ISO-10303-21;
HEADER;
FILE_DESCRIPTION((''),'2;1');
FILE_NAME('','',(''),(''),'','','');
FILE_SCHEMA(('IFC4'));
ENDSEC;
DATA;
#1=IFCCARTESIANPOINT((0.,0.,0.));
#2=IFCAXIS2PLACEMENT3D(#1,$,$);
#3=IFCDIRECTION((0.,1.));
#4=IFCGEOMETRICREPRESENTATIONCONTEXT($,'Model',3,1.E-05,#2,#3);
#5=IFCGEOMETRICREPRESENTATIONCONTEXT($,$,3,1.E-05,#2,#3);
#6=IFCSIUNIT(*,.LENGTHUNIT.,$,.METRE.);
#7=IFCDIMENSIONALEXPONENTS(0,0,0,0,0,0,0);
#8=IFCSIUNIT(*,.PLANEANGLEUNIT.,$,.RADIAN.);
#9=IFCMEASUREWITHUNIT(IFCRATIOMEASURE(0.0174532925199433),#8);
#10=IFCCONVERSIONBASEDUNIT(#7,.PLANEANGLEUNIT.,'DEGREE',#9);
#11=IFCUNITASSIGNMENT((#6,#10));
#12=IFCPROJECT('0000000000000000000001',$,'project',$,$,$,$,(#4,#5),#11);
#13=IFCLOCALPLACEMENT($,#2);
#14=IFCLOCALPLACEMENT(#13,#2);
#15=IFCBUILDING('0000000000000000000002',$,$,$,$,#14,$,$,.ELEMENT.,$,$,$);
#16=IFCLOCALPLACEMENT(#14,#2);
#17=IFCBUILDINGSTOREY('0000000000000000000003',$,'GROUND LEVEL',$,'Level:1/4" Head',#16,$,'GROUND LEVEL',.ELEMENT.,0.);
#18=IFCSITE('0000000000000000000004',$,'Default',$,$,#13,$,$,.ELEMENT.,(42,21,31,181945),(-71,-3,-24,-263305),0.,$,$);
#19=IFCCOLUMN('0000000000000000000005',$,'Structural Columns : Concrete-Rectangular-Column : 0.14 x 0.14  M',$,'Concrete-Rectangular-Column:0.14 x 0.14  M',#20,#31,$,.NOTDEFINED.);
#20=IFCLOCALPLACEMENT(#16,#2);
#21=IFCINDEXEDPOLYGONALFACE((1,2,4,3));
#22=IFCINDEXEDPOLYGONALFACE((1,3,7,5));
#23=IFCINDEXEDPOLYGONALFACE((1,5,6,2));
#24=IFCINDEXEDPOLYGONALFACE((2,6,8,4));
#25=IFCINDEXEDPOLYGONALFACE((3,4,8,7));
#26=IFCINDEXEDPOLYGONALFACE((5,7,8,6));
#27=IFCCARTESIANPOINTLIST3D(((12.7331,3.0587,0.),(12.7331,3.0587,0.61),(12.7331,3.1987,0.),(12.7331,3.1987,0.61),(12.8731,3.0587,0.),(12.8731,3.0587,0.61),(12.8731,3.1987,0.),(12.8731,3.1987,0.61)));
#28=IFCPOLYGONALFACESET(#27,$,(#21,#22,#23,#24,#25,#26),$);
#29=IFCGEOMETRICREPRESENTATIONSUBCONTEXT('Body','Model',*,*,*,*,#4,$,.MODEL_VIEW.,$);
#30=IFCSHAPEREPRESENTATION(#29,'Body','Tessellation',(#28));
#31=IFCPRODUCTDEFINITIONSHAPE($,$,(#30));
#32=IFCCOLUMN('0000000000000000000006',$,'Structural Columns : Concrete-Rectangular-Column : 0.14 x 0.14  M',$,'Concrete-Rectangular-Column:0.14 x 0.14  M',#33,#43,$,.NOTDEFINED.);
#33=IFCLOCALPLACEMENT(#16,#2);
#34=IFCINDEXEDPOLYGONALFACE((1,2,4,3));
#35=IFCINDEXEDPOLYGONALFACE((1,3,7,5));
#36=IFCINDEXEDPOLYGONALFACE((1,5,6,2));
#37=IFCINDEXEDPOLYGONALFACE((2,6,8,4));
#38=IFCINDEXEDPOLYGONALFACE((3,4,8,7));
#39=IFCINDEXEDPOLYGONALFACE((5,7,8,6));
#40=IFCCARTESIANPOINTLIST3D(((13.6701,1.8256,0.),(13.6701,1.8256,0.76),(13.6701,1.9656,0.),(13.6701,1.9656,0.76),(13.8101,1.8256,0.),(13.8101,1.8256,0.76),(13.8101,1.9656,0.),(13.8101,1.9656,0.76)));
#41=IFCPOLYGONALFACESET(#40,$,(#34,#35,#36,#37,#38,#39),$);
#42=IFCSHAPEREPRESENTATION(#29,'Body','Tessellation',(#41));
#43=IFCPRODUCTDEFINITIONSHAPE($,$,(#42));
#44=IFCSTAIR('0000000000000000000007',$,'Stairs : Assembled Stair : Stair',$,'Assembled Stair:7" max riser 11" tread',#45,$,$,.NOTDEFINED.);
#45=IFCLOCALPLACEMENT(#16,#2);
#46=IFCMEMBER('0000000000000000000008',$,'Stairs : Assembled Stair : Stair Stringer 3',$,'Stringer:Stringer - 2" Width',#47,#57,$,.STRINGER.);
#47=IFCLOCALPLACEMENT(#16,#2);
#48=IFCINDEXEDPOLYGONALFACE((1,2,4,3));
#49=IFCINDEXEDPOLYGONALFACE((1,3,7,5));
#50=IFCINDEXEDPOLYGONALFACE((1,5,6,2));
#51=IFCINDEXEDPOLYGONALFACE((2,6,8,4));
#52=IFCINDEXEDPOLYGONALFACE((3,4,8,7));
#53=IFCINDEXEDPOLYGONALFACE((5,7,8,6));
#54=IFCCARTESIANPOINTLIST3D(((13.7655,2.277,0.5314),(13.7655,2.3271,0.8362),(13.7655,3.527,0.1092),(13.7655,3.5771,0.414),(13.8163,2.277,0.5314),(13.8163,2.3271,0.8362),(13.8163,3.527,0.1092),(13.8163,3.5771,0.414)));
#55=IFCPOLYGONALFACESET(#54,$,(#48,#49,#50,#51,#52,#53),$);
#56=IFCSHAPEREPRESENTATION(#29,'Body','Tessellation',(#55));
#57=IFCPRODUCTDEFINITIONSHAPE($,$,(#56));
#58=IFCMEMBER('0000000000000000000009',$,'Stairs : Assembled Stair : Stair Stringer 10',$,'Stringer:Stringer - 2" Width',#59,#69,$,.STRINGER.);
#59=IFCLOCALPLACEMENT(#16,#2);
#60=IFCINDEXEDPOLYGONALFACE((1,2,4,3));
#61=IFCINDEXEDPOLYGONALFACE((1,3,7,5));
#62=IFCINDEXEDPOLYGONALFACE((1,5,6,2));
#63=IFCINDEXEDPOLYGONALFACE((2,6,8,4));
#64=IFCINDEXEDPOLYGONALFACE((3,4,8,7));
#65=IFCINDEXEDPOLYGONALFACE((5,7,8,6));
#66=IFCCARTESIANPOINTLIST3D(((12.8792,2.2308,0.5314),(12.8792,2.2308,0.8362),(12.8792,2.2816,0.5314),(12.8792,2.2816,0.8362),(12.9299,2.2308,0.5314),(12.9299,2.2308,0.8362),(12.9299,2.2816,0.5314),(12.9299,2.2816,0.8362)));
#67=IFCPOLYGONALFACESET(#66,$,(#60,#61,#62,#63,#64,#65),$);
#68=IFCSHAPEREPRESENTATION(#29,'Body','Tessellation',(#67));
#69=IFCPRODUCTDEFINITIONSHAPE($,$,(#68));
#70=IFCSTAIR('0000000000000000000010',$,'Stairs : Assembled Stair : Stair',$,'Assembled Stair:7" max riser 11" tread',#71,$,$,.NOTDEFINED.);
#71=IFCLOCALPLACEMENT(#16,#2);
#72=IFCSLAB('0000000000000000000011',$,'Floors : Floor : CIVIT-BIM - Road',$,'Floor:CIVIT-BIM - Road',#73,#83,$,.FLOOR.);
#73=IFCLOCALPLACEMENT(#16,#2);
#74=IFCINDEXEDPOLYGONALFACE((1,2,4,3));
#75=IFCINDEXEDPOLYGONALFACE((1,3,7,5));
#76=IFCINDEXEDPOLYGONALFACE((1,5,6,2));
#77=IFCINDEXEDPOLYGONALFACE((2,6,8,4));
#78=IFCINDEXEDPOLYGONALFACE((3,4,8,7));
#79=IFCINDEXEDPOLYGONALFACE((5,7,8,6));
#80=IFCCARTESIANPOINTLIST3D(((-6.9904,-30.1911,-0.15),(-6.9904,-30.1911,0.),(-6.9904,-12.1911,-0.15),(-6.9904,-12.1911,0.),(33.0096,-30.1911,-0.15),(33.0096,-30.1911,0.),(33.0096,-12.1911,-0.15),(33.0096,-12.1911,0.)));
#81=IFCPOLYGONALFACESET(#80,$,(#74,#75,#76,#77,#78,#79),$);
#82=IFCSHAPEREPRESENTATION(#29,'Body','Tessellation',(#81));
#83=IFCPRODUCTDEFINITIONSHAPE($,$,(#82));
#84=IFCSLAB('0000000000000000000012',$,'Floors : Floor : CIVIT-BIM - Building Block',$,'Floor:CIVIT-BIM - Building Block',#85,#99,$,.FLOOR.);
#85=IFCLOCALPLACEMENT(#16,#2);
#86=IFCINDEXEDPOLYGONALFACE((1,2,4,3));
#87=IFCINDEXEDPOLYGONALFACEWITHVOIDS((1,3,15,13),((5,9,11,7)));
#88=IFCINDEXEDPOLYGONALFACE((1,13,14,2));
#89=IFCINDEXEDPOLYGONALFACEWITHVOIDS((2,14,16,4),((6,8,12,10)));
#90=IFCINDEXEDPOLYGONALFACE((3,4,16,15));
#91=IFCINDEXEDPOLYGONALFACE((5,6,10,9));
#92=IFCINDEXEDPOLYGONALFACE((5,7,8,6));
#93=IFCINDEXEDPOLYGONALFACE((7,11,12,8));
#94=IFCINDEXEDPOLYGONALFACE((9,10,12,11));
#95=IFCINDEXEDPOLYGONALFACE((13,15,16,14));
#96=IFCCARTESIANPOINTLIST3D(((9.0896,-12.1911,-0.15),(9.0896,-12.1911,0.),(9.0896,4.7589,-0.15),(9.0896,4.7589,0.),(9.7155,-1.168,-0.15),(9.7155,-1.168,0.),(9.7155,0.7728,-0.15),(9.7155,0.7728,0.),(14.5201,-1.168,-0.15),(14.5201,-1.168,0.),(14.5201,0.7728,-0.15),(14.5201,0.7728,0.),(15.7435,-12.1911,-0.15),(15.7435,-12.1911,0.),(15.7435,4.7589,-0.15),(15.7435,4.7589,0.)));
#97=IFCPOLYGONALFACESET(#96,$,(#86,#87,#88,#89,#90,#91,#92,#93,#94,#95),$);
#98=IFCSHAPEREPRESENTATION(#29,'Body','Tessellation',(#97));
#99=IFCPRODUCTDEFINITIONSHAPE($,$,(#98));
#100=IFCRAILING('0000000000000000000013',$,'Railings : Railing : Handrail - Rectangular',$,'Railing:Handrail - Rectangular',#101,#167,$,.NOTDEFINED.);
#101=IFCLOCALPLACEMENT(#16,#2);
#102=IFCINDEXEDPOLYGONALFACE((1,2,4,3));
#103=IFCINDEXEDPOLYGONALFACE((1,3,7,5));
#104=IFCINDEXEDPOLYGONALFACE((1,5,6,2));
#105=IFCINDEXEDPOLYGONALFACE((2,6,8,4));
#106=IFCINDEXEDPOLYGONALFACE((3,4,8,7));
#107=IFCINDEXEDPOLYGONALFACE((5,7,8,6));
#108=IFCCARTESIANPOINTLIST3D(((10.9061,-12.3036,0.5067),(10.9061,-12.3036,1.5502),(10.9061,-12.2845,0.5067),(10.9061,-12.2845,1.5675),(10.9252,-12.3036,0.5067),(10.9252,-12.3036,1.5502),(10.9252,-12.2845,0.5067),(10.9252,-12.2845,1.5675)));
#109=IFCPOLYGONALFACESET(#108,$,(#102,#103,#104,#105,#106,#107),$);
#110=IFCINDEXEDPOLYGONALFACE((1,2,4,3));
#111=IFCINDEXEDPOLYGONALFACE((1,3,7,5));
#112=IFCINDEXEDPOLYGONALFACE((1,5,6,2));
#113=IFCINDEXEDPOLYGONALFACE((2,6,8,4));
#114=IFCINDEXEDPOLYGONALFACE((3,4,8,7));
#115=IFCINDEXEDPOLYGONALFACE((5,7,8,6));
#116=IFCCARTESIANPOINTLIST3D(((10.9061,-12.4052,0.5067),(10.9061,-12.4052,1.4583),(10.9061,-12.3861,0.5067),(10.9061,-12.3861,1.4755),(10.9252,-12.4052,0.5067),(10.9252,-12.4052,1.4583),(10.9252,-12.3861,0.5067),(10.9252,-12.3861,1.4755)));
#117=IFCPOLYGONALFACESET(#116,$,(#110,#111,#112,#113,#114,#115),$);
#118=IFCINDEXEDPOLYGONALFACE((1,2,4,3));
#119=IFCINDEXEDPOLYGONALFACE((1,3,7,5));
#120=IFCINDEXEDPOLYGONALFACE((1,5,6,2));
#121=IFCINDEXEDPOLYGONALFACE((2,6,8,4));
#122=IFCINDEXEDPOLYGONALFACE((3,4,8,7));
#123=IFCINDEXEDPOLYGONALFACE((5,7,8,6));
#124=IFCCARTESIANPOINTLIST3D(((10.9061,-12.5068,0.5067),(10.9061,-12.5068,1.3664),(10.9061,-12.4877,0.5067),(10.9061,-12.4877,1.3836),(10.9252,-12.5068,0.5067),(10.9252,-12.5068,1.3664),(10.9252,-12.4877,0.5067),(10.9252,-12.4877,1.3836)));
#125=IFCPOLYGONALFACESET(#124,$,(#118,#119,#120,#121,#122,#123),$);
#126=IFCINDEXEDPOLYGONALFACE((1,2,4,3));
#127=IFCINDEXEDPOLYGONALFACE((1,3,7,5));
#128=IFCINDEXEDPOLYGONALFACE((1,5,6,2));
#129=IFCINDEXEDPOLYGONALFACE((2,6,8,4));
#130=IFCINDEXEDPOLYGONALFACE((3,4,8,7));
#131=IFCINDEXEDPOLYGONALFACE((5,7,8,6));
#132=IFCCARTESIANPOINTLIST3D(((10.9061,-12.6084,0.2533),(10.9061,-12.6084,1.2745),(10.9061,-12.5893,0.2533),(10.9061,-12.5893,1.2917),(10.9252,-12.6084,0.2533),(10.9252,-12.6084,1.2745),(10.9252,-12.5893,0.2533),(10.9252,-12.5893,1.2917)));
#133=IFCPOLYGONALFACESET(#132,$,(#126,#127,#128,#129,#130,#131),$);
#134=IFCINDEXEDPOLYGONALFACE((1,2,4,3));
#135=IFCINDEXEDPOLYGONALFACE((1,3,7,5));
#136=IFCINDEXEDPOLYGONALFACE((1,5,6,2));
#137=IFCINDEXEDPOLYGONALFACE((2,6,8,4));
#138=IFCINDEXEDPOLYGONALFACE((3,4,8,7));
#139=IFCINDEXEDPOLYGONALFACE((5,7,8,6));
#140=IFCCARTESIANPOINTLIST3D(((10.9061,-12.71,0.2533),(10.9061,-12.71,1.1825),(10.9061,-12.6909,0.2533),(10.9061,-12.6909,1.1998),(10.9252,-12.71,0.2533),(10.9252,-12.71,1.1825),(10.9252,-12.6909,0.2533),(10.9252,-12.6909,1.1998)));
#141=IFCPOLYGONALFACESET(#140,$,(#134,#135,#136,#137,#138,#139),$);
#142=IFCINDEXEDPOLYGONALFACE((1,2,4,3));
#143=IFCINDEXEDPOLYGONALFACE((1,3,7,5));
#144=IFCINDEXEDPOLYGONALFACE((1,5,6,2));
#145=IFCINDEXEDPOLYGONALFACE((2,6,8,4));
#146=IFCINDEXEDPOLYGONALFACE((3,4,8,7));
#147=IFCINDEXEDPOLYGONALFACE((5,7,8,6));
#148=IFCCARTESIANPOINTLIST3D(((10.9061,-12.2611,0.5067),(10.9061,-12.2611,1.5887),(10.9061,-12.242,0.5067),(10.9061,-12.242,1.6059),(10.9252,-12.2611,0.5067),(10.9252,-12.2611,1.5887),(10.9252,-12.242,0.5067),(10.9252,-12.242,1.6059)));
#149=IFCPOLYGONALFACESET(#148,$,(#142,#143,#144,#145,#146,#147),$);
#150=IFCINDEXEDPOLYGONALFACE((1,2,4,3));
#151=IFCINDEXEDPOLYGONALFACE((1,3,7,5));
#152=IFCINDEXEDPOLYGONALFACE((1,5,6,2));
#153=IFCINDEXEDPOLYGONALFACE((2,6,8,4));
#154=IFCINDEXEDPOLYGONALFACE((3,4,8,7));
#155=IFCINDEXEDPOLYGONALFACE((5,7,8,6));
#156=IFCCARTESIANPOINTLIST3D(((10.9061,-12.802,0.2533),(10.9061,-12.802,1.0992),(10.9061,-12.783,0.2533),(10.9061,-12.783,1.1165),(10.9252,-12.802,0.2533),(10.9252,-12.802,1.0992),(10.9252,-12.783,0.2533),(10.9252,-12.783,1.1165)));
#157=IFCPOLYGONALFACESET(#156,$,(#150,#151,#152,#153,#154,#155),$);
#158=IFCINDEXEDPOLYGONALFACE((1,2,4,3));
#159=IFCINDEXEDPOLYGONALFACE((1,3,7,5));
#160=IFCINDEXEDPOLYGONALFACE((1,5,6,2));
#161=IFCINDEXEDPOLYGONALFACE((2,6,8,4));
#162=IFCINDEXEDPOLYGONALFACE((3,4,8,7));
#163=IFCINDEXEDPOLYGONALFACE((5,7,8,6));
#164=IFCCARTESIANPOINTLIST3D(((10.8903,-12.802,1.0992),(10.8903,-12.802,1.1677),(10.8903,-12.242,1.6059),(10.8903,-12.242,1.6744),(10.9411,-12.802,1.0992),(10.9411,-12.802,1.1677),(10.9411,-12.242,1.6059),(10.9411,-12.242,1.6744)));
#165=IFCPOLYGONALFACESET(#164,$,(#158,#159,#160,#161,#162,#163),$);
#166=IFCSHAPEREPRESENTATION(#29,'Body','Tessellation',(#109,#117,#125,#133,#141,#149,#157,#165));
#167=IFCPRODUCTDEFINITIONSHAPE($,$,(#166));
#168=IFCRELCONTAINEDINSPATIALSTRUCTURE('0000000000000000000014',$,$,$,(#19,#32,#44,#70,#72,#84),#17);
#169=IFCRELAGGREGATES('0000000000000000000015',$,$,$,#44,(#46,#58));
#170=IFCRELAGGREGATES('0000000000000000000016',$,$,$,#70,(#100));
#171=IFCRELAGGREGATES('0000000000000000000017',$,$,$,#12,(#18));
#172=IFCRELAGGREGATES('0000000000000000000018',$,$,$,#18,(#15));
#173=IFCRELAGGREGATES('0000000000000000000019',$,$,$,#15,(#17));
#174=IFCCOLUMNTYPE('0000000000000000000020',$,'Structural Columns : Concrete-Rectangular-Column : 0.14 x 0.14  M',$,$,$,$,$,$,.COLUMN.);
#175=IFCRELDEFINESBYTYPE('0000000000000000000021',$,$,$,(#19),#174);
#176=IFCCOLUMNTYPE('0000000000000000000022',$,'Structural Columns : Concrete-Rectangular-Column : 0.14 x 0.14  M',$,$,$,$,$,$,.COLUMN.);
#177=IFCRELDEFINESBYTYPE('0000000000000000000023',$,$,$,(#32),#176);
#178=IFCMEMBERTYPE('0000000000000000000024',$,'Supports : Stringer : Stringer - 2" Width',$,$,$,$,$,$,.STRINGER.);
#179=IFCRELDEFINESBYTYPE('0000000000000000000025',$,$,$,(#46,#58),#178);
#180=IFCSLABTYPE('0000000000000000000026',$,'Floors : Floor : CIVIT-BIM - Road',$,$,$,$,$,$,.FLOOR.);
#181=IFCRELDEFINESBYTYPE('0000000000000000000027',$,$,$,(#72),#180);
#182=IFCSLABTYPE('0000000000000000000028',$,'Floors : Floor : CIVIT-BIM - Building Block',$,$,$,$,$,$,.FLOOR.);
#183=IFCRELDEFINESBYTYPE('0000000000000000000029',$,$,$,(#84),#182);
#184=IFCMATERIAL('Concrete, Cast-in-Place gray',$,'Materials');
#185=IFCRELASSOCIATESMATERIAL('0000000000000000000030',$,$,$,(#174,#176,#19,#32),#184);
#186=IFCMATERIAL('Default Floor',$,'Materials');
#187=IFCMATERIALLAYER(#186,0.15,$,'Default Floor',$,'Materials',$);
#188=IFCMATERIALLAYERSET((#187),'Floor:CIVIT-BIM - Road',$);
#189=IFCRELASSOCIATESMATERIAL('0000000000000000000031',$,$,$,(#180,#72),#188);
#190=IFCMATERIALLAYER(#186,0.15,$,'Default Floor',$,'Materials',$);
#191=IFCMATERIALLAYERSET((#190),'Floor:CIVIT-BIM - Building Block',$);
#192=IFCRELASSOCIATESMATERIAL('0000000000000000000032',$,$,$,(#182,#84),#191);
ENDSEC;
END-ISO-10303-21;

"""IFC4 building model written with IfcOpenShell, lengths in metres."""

from ifc_helpers import new_model, entity, si_unit, converted_unit, direction, frame, frame_2d, origin, origin_2d_with_axis, place, context, subcontext, project, spatial, polyline, rectangle, outline, extrude, source, transform, mapped, material, layer, layer_set, layer_usage, material_profile, profile_set, profile_usage, type_object, type_shapes, element, aggregate, save


model = new_model("IFC4")

# Units and contexts
model_context = context("Model", 3, precision=1e-05, world=origin(), true_north=direction((0.0, 1.0)))
context_of_model = context(None, 3, precision=1e-05, world=origin(), true_north=direction((0.0, 1.0)))
body_context = subcontext(model_context, "Body", "Model", "MODEL_VIEW")
ifc_project = project(units=[si_unit("LENGTHUNIT", "METRE"), converted_unit("PLANEANGLEUNIT", "DEGREE", entity("IfcRatioMeasure", 0.0174532925199433), si_unit("PLANEANGLEUNIT", "RADIAN"), dimensions=[0, 0, 0, 0, 0, 0, 0])], contexts=[model_context, context_of_model])

# Site, building, storey
site_placement = place(None, origin())
site = spatial("IfcSite", under=ifc_project, at=site_placement, Name="Default", CompositionType="ELEMENT", RefLatitude=(42, 21, 31, 181945), RefLongitude=(-71, -3, -24, -263305), RefElevation=0.0)
building_placement = place(site_placement, origin())
building = spatial("IfcBuilding", under=site, at=building_placement, CompositionType="ELEMENT")
storey_placement = place(building_placement, origin())
storey = spatial("IfcBuildingStorey", under=building, at=storey_placement, Name="GROUND LEVEL", ObjectType="Level:1/4\" Head", LongName="GROUND LEVEL", CompositionType="ELEMENT", Elevation=0.0)

# Columns
ifc_material_1 = material(Name="Concrete, Cast-in-Place gray", Category="Materials")
ifc_material_profile = material_profile(ifc_material_1, rectangle(XDim=0.14, YDim=0.14, at=origin_2d_with_axis()), Name="0.14 x 0.14  M")
ifc_profile_set = profile_set([ifc_material_profile], Name="0.14 x 0.14  M")
ifc_profile_usage_1 = profile_usage(ifc_profile_set)
column_type_1 = type_object("IfcColumnType", Name="Structural Columns : Concrete-Rectangular-Column : 0.14 x 0.14  M", PredefinedType="COLUMN", material=ifc_profile_set)
shared_shape_1 = source(origin(), body_context, "Body", "SweptSolid", [
    extrude(rectangle(XDim=0.14, YDim=0.14, at=origin_2d_with_axis()), frame((12.8031, 3.1287, 0.0), z_axis=(0.0, 0.0, 1.0), x_axis=(0.0, -1.0, 0.0)), (0.0, 0.0, 1.0), 0.61),
])
type_shapes(column_type_1, [shared_shape_1])
column_1_placement = place(storey_placement, origin())
element("IfcColumn", 1, at=column_1_placement, inside=storey, type_object=column_type_1, material=ifc_profile_usage_1, Name="Structural Columns : Concrete-Rectangular-Column : 0.14 x 0.14  M", ObjectType="Concrete-Rectangular-Column:0.14 x 0.14  M", PredefinedType="NOTDEFINED", context=body_context, shape_type="MappedRepresentation", body=[
    mapped(shared_shape_1, transform((0.0, 0.0, 0.0), scale=1.0)),
])
ifc_profile_usage_2 = profile_usage(ifc_profile_set)
column_type_2 = type_object("IfcColumnType", Name="Structural Columns : Concrete-Rectangular-Column : 0.14 x 0.14  M", PredefinedType="COLUMN", material=ifc_profile_set)
shared_shape_2 = source(origin(), body_context, "Body", "SweptSolid", [
    extrude(rectangle(XDim=0.14, YDim=0.14, at=frame_2d((0.0, 0.0), x_axis=(1.0, 0.0))), frame((13.7401, 1.8956, 0.0), z_axis=(0.0, 0.0, 1.0), x_axis=(0.0, -1.0, 0.0)), (0.0, 0.0, 1.0), 0.76),
])
type_shapes(column_type_2, [shared_shape_2])
column_2_placement = place(storey_placement, origin())
element("IfcColumn", 2, at=column_2_placement, inside=storey, type_object=column_type_2, material=ifc_profile_usage_2, Name="Structural Columns : Concrete-Rectangular-Column : 0.14 x 0.14  M", ObjectType="Concrete-Rectangular-Column:0.14 x 0.14  M", PredefinedType="NOTDEFINED", context=body_context, shape_type="MappedRepresentation", body=[
    mapped(shared_shape_2, transform((0.0, 0.0, 0.0), scale=1.0)),
])

# Stairs, members
stair_1_placement = place(storey_placement, origin())
stair_1 = element("IfcStair", 3, at=stair_1_placement, inside=storey, Name="Stairs : Assembled Stair : Stair", ObjectType="Assembled Stair:7\" max riser 11\" tread", PredefinedType="NOTDEFINED")
member_type = type_object("IfcMemberType", Name="Supports : Stringer : Stringer - 2\" Width", PredefinedType="STRINGER")
member_1_placement = place(stair_1_placement, frame((13.7655, 2.277, 0.1092)))
member_1 = element("IfcMember", 4, at=member_1_placement, type_object=member_type, Name="Stairs : Assembled Stair : Stair Stringer 3", ObjectType="Stringer:Stringer - 2\" Width", PredefinedType="STRINGER", context=body_context, shape_type="SweptSolid", body=[
    extrude(outline(polyline([(-0.6346, -0.1524), (0.6847, -0.1524), (0.6346, 0.1524), (-0.6847, 0.1524), (-0.6346, -0.1524)])), frame((0.0, 0.65, 0.3635), z_axis=(1.0, 0.0, 0.0), x_axis=(0.0, -0.947413, 0.320015)), (0.0, 0.0, 1.0), 0.0508),
])
member_2_placement = place(stair_1_placement, frame((12.8792, 2.2308, 0.5314)))
member_2 = element("IfcMember", 5, at=member_2_placement, type_object=member_type, Name="Stairs : Assembled Stair : Stair Stringer 10", ObjectType="Stringer:Stringer - 2\" Width", PredefinedType="STRINGER", context=body_context, shape_type="SweptSolid", body=[
    extrude(rectangle(XDim=0.0507, YDim=0.0508, at=frame_2d((0.0, 0.0), x_axis=(1.0, 0.0))), frame((0.0253, 0.0254, 0.0), z_axis=(0.0, 0.0, 1.0), x_axis=(-1.0, 0.0, 0.0)), (0.0, 0.0, 1.0), 0.3048),
])
aggregate(stair_1, [member_1, member_2])
stair_2_placement = place(storey_placement, origin())
stair_2 = element("IfcStair", 6, at=stair_2_placement, inside=storey, Name="Stairs : Assembled Stair : Stair", ObjectType="Assembled Stair:7\" max riser 11\" tread", PredefinedType="NOTDEFINED")

# Shared definitions
ifc_material_2 = material(Name="Default Floor", Category="Materials")

# Slab
ifc_layer_1 = layer(ifc_material_2, 0.15, Name="Default Floor", Category="Materials")
ifc_layer_set_1 = layer_set([ifc_layer_1], Name="Floor:CIVIT-BIM - Road")
ifc_layer_usage_1 = layer_usage(ifc_layer_set_1, "AXIS3", "POSITIVE", 0.0)
slab_type_1 = type_object("IfcSlabType", Name="Floors : Floor : CIVIT-BIM - Road", PredefinedType="FLOOR", material=ifc_layer_set_1)
slab_1_placement = place(storey_placement, origin())
element("IfcSlab", 7, at=slab_1_placement, inside=storey, type_object=slab_type_1, material=ifc_layer_usage_1, Name="Floors : Floor : CIVIT-BIM - Road", ObjectType="Floor:CIVIT-BIM - Road", PredefinedType="FLOOR", context=body_context, shape_type="SweptSolid", body=[
    extrude(rectangle(XDim=18.0, YDim=40.0, at=frame_2d((0.0, 0.0), x_axis=(1.0, 0.0))), frame((13.0096, -21.1911, 0.0), z_axis=(0.0, 0.0, -1.0), x_axis=(0.0, 1.0, 0.0)), (0.0, 0.0, 1.0), 0.15),
])

# Slab, opening
ifc_layer_2 = layer(ifc_material_2, 0.15, Name="Default Floor", Category="Materials")
ifc_layer_set_2 = layer_set([ifc_layer_2], Name="Floor:CIVIT-BIM - Building Block")
ifc_layer_usage_2 = layer_usage(ifc_layer_set_2, "AXIS3", "POSITIVE", 0.0)
slab_type_2 = type_object("IfcSlabType", Name="Floors : Floor : CIVIT-BIM - Building Block", PredefinedType="FLOOR", material=ifc_layer_set_2)
slab_2_placement = place(storey_placement, frame((9.0896, -12.1911, -0.15)))
slab_2 = element("IfcSlab", 8, at=slab_2_placement, inside=storey, type_object=slab_type_2, material=ifc_layer_usage_2, Name="Floors : Floor : CIVIT-BIM - Building Block", ObjectType="Floor:CIVIT-BIM - Building Block", PredefinedType="FLOOR", context=body_context, shape_type="SweptSolid", body=[
    extrude(rectangle(XDim=16.95, YDim=6.654, at=frame_2d((0.0, 0.0), x_axis=(0.0, -1.0))), frame((3.327, 8.475, 0.15), z_axis=(0.0, 0.0, -1.0), x_axis=(-1.0, 0.0, 0.0)), (0.0, 0.0, 1.0), 0.15),
])
opening_1_placement = place(slab_2_placement, frame((3.0282, 11.9936, 0.15)))
element("IfcOpeningElement", 9, at=opening_1_placement, cuts=slab_2, ObjectType="Opening", context=body_context, shape_type="SweptSolid", body=[
    extrude(rectangle(XDim=4.8046, YDim=1.9408, at=origin_2d_with_axis()), frame((0.0, 0.0, 0.0), z_axis=(0.0, 0.0, -1.0), x_axis=(1.0, 0.0, 0.0)), (0.0, 0.0, 1.0), 0.15),
])

# Railing
railing_1_placement = place(stair_2_placement, frame((10.8903, -12.802, 0.2533)))
railing_1 = element("IfcRailing", 10, at=railing_1_placement, Name="Railings : Railing : Handrail - Rectangular", ObjectType="Railing:Handrail - Rectangular", PredefinedType="NOTDEFINED", context=body_context, shape_type="SweptSolid", body=[
    extrude(outline(polyline([(-0.5175, -0.0095), (0.5261, -0.0095), (0.5261, 0.0095), (-0.5347, 0.0095), (-0.5175, -0.0095)])), frame((0.0159, 0.508, 0.7794), z_axis=(1.0, 0.0, 0.0), x_axis=(0.0, 0.0, -1.0)), (0.0, 0.0, 1.0), 0.0191),
    extrude(outline(polyline([(-0.4715, -0.0095), (0.4801, -0.0095), (0.4801, 0.0095), (-0.4887, 0.0095), (-0.4715, -0.0095)])), frame((0.0159, 0.4064, 0.7335), z_axis=(1.0, 0.0, 0.0), x_axis=(0.0, 0.0, -1.0)), (0.0, 0.0, 1.0), 0.0191),
    extrude(outline(polyline([(-0.4255, -0.0095), (0.4342, -0.0095), (0.4342, 0.0095), (-0.4428, 0.0095), (-0.4255, -0.0095)])), frame((0.0159, 0.3048, 0.6875), z_axis=(1.0, 0.0, 0.0), x_axis=(0.0, 0.0, -1.0)), (0.0, 0.0, 1.0), 0.0191),
    extrude(outline(polyline([(-0.5063, -0.0095), (0.5149, -0.0095), (0.5149, 0.0095), (-0.5235, 0.0095), (-0.5063, -0.0095)])), frame((0.0159, 0.2032, 0.5149), z_axis=(1.0, 0.0, 0.0), x_axis=(0.0, 0.0, -1.0)), (0.0, 0.0, 1.0), 0.0191),
    extrude(outline(polyline([(-0.4603, -0.0095), (0.4689, -0.0095), (0.4689, 0.0095), (-0.4775, 0.0095), (-0.4603, -0.0095)])), frame((0.0159, 0.1016, 0.4689), z_axis=(1.0, 0.0, 0.0), x_axis=(0.0, 0.0, -1.0)), (0.0, 0.0, 1.0), 0.0191),
    extrude(outline(polyline([(-0.5367, -0.0095), (0.5453, -0.0095), (0.5453, 0.0095), (-0.5539, 0.0095), (-0.5367, -0.0095)])), frame((0.0159, 0.5505, 0.7986), z_axis=(1.0, 0.0, 0.0), x_axis=(0.0, 0.0, -1.0)), (0.0, 0.0, 1.0), 0.0191),
    extrude(outline(polyline([(-0.4186, -0.0095), (0.4273, -0.0095), (0.4273, 0.0095), (-0.4359, 0.0095), (-0.4186, -0.0095)])), frame((0.0159, 0.0095, 0.4273), z_axis=(1.0, 0.0, 0.0), x_axis=(0.0, 0.0, -1.0)), (0.0, 0.0, 1.0), 0.0191),
    extrude(outline(polyline([(-0.4006, -0.0254), (0.3546, -0.0254), (0.4006, 0.0254), (-0.3546, 0.0254), (-0.4006, -0.0254)])), frame((0.0, 0.28, 1.1335), z_axis=(1.0, 0.0, 0.0), x_axis=(0.0, 0.741536, 0.670913)), (0.0, 0.0, 1.0), 0.0508),
])
aggregate(stair_2, [railing_1])

save(model, "model.ifc")
